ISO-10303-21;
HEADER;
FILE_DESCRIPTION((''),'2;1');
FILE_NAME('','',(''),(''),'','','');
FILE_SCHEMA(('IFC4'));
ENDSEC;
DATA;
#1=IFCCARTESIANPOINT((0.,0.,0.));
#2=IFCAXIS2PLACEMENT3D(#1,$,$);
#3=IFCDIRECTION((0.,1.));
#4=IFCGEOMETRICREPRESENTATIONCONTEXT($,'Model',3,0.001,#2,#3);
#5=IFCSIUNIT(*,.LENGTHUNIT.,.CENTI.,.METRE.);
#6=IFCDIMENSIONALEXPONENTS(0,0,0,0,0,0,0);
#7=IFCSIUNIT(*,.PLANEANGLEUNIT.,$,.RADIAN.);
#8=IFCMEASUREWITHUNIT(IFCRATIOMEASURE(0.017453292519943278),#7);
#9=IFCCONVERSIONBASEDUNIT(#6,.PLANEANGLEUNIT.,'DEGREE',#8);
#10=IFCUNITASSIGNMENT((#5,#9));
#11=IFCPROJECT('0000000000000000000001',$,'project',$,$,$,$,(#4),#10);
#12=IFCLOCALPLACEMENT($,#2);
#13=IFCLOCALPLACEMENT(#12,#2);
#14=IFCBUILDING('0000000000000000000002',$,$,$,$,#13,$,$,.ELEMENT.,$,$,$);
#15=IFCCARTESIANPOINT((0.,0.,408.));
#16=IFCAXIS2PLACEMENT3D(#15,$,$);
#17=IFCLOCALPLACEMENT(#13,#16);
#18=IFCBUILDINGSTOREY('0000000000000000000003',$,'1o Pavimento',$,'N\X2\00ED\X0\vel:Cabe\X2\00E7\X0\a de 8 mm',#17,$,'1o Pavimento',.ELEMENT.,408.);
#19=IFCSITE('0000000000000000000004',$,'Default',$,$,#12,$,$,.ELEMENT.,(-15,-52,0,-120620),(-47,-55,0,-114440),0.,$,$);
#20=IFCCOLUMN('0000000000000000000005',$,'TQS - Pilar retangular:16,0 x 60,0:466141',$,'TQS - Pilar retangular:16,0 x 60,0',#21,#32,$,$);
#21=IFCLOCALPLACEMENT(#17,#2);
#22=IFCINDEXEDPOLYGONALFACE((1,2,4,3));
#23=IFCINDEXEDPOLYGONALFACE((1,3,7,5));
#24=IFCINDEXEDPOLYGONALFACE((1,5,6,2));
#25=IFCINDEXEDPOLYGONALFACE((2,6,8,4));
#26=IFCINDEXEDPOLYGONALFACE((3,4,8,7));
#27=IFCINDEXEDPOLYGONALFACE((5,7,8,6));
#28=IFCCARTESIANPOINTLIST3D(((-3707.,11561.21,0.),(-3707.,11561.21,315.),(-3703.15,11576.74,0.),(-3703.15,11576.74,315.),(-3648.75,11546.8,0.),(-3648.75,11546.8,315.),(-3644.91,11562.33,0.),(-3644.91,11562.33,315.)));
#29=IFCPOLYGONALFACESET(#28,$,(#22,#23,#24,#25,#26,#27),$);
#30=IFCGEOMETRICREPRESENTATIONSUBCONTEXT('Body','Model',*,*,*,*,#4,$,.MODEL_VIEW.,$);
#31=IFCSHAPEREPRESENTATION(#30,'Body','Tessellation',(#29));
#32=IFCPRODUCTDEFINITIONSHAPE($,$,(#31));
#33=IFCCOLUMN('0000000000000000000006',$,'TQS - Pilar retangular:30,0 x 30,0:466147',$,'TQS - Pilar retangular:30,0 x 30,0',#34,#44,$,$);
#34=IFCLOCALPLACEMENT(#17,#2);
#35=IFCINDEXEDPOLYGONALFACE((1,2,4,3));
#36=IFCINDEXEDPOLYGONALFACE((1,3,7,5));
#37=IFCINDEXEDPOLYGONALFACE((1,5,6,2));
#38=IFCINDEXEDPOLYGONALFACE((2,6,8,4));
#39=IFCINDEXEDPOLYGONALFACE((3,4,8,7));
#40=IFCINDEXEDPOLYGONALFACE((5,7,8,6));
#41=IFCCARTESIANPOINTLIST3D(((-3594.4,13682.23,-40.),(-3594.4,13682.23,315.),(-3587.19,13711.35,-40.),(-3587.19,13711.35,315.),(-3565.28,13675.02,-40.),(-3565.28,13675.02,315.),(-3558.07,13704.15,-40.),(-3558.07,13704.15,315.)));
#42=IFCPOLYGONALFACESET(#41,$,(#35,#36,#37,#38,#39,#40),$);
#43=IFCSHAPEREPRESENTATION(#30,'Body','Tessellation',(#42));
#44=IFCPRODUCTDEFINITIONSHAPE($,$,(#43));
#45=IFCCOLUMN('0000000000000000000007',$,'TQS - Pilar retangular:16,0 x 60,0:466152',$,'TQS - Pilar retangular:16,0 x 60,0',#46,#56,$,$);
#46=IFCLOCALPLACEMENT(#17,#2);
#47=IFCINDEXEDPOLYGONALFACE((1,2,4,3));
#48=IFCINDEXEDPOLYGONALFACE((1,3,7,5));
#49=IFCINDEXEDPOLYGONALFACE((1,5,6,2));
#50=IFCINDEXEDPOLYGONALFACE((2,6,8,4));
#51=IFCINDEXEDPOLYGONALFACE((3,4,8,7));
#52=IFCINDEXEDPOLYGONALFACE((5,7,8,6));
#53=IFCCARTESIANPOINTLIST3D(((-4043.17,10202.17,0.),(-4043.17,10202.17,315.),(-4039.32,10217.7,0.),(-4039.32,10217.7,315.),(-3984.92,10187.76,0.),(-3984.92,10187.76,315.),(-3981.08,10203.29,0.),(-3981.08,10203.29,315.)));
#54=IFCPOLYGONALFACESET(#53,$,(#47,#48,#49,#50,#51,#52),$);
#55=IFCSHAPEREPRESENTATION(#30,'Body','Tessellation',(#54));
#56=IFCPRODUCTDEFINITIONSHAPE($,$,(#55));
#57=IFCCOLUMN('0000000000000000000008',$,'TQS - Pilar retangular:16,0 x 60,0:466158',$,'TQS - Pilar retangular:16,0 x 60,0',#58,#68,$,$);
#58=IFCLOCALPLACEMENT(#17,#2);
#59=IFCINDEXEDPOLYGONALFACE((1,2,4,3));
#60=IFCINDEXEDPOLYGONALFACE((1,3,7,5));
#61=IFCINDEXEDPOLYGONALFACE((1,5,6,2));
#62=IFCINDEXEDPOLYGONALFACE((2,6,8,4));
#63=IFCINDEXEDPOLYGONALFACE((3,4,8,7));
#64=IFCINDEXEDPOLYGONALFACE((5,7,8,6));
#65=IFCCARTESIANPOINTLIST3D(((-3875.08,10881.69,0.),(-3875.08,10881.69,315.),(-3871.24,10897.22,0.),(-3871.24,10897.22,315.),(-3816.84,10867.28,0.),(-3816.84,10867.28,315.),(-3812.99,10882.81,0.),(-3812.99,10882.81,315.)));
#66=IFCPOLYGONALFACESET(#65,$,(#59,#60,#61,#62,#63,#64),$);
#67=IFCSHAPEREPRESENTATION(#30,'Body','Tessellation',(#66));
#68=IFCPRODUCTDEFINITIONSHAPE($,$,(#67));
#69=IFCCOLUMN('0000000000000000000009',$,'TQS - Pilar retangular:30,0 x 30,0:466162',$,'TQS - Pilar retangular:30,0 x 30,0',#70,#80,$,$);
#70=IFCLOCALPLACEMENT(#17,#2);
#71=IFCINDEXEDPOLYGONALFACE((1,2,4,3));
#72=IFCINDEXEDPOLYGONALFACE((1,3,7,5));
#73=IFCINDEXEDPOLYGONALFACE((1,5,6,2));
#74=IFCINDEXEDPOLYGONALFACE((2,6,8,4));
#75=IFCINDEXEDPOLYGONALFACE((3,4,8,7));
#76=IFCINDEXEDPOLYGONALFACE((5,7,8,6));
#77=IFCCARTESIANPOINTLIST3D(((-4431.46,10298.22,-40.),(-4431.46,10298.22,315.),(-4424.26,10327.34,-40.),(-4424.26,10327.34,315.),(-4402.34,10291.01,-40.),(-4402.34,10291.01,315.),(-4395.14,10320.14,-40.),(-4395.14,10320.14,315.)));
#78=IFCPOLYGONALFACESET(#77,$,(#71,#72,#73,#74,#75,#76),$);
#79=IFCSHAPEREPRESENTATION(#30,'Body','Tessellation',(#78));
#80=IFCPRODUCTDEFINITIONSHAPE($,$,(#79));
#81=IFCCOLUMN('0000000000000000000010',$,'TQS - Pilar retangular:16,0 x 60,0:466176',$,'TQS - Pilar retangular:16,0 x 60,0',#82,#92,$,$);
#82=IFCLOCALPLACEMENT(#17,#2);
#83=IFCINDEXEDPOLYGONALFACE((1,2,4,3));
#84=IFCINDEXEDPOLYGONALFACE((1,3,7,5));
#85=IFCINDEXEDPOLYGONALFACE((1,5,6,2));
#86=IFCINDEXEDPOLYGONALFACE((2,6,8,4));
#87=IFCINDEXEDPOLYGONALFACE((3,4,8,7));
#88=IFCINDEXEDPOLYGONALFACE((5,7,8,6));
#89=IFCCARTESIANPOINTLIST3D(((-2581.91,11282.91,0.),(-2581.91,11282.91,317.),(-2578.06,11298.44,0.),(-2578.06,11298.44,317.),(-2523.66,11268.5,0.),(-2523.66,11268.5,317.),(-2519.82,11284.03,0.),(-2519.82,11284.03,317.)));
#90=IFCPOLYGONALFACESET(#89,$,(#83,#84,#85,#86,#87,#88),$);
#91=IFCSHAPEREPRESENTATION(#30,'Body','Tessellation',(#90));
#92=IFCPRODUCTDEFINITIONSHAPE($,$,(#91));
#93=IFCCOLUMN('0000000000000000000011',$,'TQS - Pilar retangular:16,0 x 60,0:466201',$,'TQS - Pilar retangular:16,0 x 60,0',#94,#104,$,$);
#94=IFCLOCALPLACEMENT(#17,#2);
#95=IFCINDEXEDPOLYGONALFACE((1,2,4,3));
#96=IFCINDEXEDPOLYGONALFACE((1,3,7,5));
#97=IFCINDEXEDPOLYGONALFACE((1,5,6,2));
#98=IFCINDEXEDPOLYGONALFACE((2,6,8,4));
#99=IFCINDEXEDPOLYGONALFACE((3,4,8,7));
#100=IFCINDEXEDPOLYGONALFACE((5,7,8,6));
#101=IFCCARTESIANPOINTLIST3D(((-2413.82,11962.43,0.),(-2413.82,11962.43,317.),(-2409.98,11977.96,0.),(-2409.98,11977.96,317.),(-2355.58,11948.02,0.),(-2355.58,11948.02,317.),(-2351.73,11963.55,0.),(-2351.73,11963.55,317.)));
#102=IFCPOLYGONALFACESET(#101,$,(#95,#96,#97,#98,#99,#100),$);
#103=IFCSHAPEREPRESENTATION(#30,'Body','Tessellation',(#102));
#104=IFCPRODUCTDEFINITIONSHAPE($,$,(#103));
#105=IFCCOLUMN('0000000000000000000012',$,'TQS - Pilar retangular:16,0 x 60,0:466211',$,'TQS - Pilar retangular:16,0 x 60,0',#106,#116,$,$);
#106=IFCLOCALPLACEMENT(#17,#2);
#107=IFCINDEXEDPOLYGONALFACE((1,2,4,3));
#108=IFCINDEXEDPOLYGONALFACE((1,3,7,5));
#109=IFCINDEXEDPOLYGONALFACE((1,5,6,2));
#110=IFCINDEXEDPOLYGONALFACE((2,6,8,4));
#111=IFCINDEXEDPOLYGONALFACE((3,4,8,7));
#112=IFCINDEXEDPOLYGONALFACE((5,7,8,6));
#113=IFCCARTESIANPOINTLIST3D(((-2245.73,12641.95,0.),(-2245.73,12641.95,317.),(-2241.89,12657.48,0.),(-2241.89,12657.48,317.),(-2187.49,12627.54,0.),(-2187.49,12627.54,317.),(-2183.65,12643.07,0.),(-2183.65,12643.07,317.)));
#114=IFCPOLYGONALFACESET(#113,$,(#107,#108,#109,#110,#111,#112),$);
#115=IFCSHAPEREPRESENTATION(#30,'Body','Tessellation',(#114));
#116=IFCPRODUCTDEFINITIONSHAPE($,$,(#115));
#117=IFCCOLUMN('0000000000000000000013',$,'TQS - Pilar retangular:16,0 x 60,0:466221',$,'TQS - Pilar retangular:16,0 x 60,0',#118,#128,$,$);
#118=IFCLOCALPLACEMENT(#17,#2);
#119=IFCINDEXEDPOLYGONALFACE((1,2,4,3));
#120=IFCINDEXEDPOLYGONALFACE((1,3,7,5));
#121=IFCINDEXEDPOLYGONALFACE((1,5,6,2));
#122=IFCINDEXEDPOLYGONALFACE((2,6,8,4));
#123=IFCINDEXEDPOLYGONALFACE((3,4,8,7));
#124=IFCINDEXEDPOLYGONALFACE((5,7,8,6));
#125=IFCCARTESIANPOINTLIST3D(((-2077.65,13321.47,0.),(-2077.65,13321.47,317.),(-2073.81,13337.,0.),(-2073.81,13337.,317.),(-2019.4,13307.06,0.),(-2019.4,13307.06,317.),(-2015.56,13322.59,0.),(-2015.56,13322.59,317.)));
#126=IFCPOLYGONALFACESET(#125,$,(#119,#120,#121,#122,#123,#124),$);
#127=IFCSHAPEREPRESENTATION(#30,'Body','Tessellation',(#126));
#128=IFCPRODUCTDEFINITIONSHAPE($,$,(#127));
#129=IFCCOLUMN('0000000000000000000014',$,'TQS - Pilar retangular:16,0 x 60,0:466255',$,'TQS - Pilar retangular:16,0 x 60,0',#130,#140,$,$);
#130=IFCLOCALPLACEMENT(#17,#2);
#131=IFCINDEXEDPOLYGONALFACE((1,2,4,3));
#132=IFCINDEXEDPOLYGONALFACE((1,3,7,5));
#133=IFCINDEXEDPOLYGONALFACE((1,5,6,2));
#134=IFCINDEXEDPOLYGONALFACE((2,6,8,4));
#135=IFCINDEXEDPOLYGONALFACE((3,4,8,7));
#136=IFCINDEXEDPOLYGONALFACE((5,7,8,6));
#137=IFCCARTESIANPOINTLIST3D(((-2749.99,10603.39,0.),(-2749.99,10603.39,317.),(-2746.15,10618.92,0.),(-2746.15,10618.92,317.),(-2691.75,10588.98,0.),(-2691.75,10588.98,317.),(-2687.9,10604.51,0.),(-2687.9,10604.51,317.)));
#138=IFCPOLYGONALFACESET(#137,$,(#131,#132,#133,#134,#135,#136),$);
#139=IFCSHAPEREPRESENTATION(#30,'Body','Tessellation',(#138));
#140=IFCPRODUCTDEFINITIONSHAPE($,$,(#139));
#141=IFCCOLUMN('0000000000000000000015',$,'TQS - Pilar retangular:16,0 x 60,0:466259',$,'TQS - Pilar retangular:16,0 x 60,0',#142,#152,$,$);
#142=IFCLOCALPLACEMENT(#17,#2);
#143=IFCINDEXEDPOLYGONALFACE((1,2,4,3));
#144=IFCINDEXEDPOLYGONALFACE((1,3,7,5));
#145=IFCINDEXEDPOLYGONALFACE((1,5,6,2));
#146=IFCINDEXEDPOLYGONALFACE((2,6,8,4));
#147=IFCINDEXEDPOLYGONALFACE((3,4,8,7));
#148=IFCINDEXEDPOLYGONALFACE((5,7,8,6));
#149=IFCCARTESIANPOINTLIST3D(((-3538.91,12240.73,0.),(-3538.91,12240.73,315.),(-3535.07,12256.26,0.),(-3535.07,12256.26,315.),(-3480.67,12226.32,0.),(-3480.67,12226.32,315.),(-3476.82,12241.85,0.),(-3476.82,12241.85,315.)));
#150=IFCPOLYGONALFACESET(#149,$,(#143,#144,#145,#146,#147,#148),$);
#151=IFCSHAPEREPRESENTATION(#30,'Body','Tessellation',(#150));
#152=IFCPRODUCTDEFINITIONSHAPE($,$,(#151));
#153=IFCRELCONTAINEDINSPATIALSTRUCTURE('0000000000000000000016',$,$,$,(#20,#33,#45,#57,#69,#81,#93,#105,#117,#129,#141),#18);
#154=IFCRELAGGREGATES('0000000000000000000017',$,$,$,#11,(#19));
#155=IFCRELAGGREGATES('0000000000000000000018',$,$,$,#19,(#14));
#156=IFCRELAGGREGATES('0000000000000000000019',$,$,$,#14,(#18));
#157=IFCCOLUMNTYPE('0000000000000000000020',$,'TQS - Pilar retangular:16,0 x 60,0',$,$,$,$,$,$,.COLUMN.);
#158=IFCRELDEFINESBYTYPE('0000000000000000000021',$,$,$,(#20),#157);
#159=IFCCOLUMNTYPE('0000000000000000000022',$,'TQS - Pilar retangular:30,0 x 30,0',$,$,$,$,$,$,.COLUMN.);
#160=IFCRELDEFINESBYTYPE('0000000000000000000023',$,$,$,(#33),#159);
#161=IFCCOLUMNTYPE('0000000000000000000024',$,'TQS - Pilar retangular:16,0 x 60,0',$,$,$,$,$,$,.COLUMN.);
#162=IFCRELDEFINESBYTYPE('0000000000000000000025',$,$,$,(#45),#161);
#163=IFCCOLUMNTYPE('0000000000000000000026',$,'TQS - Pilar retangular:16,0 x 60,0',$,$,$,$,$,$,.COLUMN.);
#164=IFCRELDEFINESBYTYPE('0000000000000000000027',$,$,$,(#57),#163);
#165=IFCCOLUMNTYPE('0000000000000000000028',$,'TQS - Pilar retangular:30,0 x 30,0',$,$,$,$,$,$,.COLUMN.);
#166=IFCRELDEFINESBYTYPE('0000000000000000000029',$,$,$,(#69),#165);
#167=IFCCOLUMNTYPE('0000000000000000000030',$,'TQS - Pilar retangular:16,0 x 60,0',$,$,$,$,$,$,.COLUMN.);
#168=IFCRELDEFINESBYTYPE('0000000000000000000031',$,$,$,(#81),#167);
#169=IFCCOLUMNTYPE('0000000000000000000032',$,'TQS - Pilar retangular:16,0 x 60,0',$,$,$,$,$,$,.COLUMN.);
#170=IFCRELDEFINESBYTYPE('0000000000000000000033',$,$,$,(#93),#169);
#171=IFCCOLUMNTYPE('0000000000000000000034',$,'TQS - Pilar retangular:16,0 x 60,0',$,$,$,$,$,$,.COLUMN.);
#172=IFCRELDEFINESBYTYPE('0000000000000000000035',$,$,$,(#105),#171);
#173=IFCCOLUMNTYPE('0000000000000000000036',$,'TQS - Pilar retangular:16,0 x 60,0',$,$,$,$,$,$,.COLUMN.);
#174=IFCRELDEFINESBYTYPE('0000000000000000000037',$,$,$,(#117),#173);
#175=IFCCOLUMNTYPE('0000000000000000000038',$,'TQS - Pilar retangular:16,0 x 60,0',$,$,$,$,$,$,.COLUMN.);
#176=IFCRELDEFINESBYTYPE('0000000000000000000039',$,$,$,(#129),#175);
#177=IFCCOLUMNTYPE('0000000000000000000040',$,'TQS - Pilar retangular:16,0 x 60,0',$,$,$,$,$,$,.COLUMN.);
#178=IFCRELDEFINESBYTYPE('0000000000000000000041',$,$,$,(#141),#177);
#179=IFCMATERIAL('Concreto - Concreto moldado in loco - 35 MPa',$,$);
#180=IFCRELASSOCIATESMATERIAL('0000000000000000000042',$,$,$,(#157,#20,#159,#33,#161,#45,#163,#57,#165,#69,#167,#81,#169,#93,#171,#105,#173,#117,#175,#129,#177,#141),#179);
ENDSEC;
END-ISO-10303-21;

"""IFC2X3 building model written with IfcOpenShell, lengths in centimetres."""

from ifc_helpers import new_model, entity, si_unit, converted_unit, direction, frame, frame_2d, origin, origin_2d_with_axis, place, context, subcontext, project, spatial, rectangle, extrude, source, transform, mapped, material, type_object, type_shapes, element, save


model = new_model("IFC2X3")

# Units and contexts
model_context = context("Model", 3, precision=0.001, world=origin(), true_north=direction((0.0, 1.0)))
body_context = subcontext(model_context, "Body", "Model", "MODEL_VIEW")
ifc_project = project(units=[si_unit("LENGTHUNIT", "METRE", prefix="CENTI"), converted_unit("PLANEANGLEUNIT", "DEGREE", entity("IfcRatioMeasure", 0.017453292519943278), si_unit("PLANEANGLEUNIT", "RADIAN"), dimensions=[0, 0, 0, 0, 0, 0, 0])], contexts=[model_context])

# Site, building, storey
site_placement = place(None, origin())
site = spatial("IfcSite", under=ifc_project, at=site_placement, Name="Default", CompositionType="ELEMENT", RefLatitude=(-15, -52, 0, -120620), RefLongitude=(-47, -55, 0, -114440), RefElevation=0.0)
building_placement = place(site_placement, origin())
building = spatial("IfcBuilding", under=site, at=building_placement, CompositionType="ELEMENT")
storey_placement = place(building_placement, frame((0.0, 0.0, 408.0)))
storey = spatial("IfcBuildingStorey", under=building, at=storey_placement, Name="1o Pavimento", ObjectType="Nível:Cabeça de 8 mm", LongName="1o Pavimento", CompositionType="ELEMENT", Elevation=408.0)

# Columns
ifc_material = material(Name="Concreto - Concreto moldado in loco - 35 MPa")
column_type_1 = type_object("IfcColumnType", Name="TQS - Pilar retangular:16,0 x 60,0", PredefinedType="COLUMN", material=ifc_material)
shared_shape_1 = source(origin(), body_context, "Body", "SweptSolid", [
    extrude(rectangle(XDim=60.0, YDim=16.0, at=origin_2d_with_axis()), frame((-3675.95, 11561.77, 408.0), z_axis=(0.0, 0.0, 1.0), x_axis=(-0.970743, 0.240122, 0.0)), (0.0, 0.0, 1.0), 315.0),
])
type_shapes(column_type_1, [shared_shape_1])
column_1_placement = place(storey_placement, frame((0.0, 0.0, -408.0)))
element("IfcColumn", 1, at=column_1_placement, inside=storey, type_object=column_type_1, material=ifc_material, Name="TQS - Pilar retangular:16,0 x 60,0:466141", ObjectType="TQS - Pilar retangular:16,0 x 60,0", context=body_context, shape_type="MappedRepresentation", body=[
    mapped(shared_shape_1, transform((0.0, 0.0, 0.0), scale=1.0)),
])
column_type_2 = type_object("IfcColumnType", Name="TQS - Pilar retangular:30,0 x 30,0", PredefinedType="COLUMN", material=ifc_material)
shared_shape_2 = source(origin(), body_context, "Body", "SweptSolid", [
    extrude(rectangle(XDim=30.0, YDim=30.0, at=frame_2d((0.0, 0.0), x_axis=(1.0, 0.0))), frame((-3576.24, 13693.19, 368.0), z_axis=(0.0, 0.0, 1.0), x_axis=(-0.970743, 0.240122, 0.0)), (0.0, 0.0, 1.0), 355.0),
])
type_shapes(column_type_2, [shared_shape_2])
column_2_placement = place(storey_placement, frame((0.0, 0.0, -408.0)))
element("IfcColumn", 2, at=column_2_placement, inside=storey, type_object=column_type_2, material=ifc_material, Name="TQS - Pilar retangular:30,0 x 30,0:466147", ObjectType="TQS - Pilar retangular:30,0 x 30,0", context=body_context, shape_type="MappedRepresentation", body=[
    mapped(shared_shape_2, transform((0.0, 0.0, 0.0), scale=1.0)),
])
column_type_3 = type_object("IfcColumnType", Name="TQS - Pilar retangular:16,0 x 60,0", PredefinedType="COLUMN", material=ifc_material)
shared_shape_3 = source(origin(), body_context, "Body", "SweptSolid", [
    extrude(rectangle(XDim=60.0, YDim=16.0, at=origin_2d_with_axis()), frame((-4012.12, 10202.73, 408.0), z_axis=(0.0, 0.0, 1.0), x_axis=(-0.970743, 0.240122, 0.0)), (0.0, 0.0, 1.0), 315.0),
])
type_shapes(column_type_3, [shared_shape_3])
column_3_placement = place(storey_placement, frame((0.0, 0.0, -408.0)))
element("IfcColumn", 3, at=column_3_placement, inside=storey, type_object=column_type_3, material=ifc_material, Name="TQS - Pilar retangular:16,0 x 60,0:466152", ObjectType="TQS - Pilar retangular:16,0 x 60,0", context=body_context, shape_type="MappedRepresentation", body=[
    mapped(shared_shape_3, transform((0.0, 0.0, 0.0), scale=1.0)),
])
column_type_4 = type_object("IfcColumnType", Name="TQS - Pilar retangular:16,0 x 60,0", PredefinedType="COLUMN", material=ifc_material)
shared_shape_4 = source(origin(), body_context, "Body", "SweptSolid", [
    extrude(rectangle(XDim=60.0, YDim=16.0, at=origin_2d_with_axis()), frame((-3844.04, 10882.25, 408.0), z_axis=(0.0, 0.0, 1.0), x_axis=(-0.970743, 0.240122, 0.0)), (0.0, 0.0, 1.0), 315.0),
])
type_shapes(column_type_4, [shared_shape_4])
column_4_placement = place(storey_placement, frame((0.0, 0.0, -408.0)))
element("IfcColumn", 4, at=column_4_placement, inside=storey, type_object=column_type_4, material=ifc_material, Name="TQS - Pilar retangular:16,0 x 60,0:466158", ObjectType="TQS - Pilar retangular:16,0 x 60,0", context=body_context, shape_type="MappedRepresentation", body=[
    mapped(shared_shape_4, transform((0.0, 0.0, 0.0), scale=1.0)),
])
column_type_5 = type_object("IfcColumnType", Name="TQS - Pilar retangular:30,0 x 30,0", PredefinedType="COLUMN", material=ifc_material)
shared_shape_5 = source(origin(), body_context, "Body", "SweptSolid", [
    extrude(rectangle(XDim=30.0, YDim=30.0, at=origin_2d_with_axis()), frame((-4413.3, 10309.18, 368.0), z_axis=(0.0, 0.0, 1.0), x_axis=(-0.970743, 0.240122, 0.0)), (0.0, 0.0, 1.0), 355.0),
])
type_shapes(column_type_5, [shared_shape_5])
column_5_placement = place(storey_placement, frame((0.0, 0.0, -408.0)))
element("IfcColumn", 5, at=column_5_placement, inside=storey, type_object=column_type_5, material=ifc_material, Name="TQS - Pilar retangular:30,0 x 30,0:466162", ObjectType="TQS - Pilar retangular:30,0 x 30,0", context=body_context, shape_type="MappedRepresentation", body=[
    mapped(shared_shape_5, transform((0.0, 0.0, 0.0), scale=1.0)),
])
column_type_6 = type_object("IfcColumnType", Name="TQS - Pilar retangular:16,0 x 60,0", PredefinedType="COLUMN", material=ifc_material)
shared_shape_6 = source(origin(), body_context, "Body", "SweptSolid", [
    extrude(rectangle(XDim=60.0, YDim=16.0, at=origin_2d_with_axis()), frame((-2550.86, 11283.47, 408.0), z_axis=(0.0, 0.0, 1.0), x_axis=(-0.970743, 0.240122, 0.0)), (0.0, 0.0, 1.0), 317.0),
])
type_shapes(column_type_6, [shared_shape_6])
column_6_placement = place(storey_placement, frame((0.0, 0.0, -408.0)))
element("IfcColumn", 6, at=column_6_placement, inside=storey, type_object=column_type_6, material=ifc_material, Name="TQS - Pilar retangular:16,0 x 60,0:466176", ObjectType="TQS - Pilar retangular:16,0 x 60,0", context=body_context, shape_type="MappedRepresentation", body=[
    mapped(shared_shape_6, transform((0.0, 0.0, 0.0), scale=1.0)),
])
column_type_7 = type_object("IfcColumnType", Name="TQS - Pilar retangular:16,0 x 60,0", PredefinedType="COLUMN", material=ifc_material)
shared_shape_7 = source(origin(), body_context, "Body", "SweptSolid", [
    extrude(rectangle(XDim=60.0, YDim=16.0, at=origin_2d_with_axis()), frame((-2382.78, 11962.99, 408.0), z_axis=(0.0, 0.0, 1.0), x_axis=(-0.970743, 0.240122, 0.0)), (0.0, 0.0, 1.0), 317.0),
])
type_shapes(column_type_7, [shared_shape_7])
column_7_placement = place(storey_placement, frame((0.0, 0.0, -408.0)))
element("IfcColumn", 7, at=column_7_placement, inside=storey, type_object=column_type_7, material=ifc_material, Name="TQS - Pilar retangular:16,0 x 60,0:466201", ObjectType="TQS - Pilar retangular:16,0 x 60,0", context=body_context, shape_type="MappedRepresentation", body=[
    mapped(shared_shape_7, transform((0.0, 0.0, 0.0), scale=1.0)),
])
column_type_8 = type_object("IfcColumnType", Name="TQS - Pilar retangular:16,0 x 60,0", PredefinedType="COLUMN", material=ifc_material)
shared_shape_8 = source(origin(), body_context, "Body", "SweptSolid", [
    extrude(rectangle(XDim=60.0, YDim=16.0, at=origin_2d_with_axis()), frame((-2214.69, 12642.51, 408.0), z_axis=(0.0, 0.0, 1.0), x_axis=(-0.970743, 0.240122, 0.0)), (0.0, 0.0, 1.0), 317.0),
])
type_shapes(column_type_8, [shared_shape_8])
column_8_placement = place(storey_placement, frame((0.0, 0.0, -408.0)))
element("IfcColumn", 8, at=column_8_placement, inside=storey, type_object=column_type_8, material=ifc_material, Name="TQS - Pilar retangular:16,0 x 60,0:466211", ObjectType="TQS - Pilar retangular:16,0 x 60,0", context=body_context, shape_type="MappedRepresentation", body=[
    mapped(shared_shape_8, transform((0.0, 0.0, 0.0), scale=1.0)),
])
column_type_9 = type_object("IfcColumnType", Name="TQS - Pilar retangular:16,0 x 60,0", PredefinedType="COLUMN", material=ifc_material)
shared_shape_9 = source(origin(), body_context, "Body", "SweptSolid", [
    extrude(rectangle(XDim=60.0, YDim=16.0, at=origin_2d_with_axis()), frame((-2046.61, 13322.03, 408.0), z_axis=(0.0, 0.0, 1.0), x_axis=(-0.970743, 0.240122, 0.0)), (0.0, 0.0, 1.0), 317.0),
])
type_shapes(column_type_9, [shared_shape_9])
column_9_placement = place(storey_placement, frame((0.0, 0.0, -408.0)))
element("IfcColumn", 9, at=column_9_placement, inside=storey, type_object=column_type_9, material=ifc_material, Name="TQS - Pilar retangular:16,0 x 60,0:466221", ObjectType="TQS - Pilar retangular:16,0 x 60,0", context=body_context, shape_type="MappedRepresentation", body=[
    mapped(shared_shape_9, transform((0.0, 0.0, 0.0), scale=1.0)),
])
column_type_10 = type_object("IfcColumnType", Name="TQS - Pilar retangular:16,0 x 60,0", PredefinedType="COLUMN", material=ifc_material)
shared_shape_10 = source(origin(), body_context, "Body", "SweptSolid", [
    extrude(rectangle(XDim=60.0, YDim=16.0, at=origin_2d_with_axis()), frame((-2718.95, 10603.95, 408.0), z_axis=(0.0, 0.0, 1.0), x_axis=(-0.970743, 0.240122, 0.0)), (0.0, 0.0, 1.0), 317.0),
])
type_shapes(column_type_10, [shared_shape_10])
column_10_placement = place(storey_placement, frame((0.0, 0.0, -408.0)))
element("IfcColumn", 10, at=column_10_placement, inside=storey, type_object=column_type_10, material=ifc_material, Name="TQS - Pilar retangular:16,0 x 60,0:466255", ObjectType="TQS - Pilar retangular:16,0 x 60,0", context=body_context, shape_type="MappedRepresentation", body=[
    mapped(shared_shape_10, transform((0.0, 0.0, 0.0), scale=1.0)),
])
column_type_11 = type_object("IfcColumnType", Name="TQS - Pilar retangular:16,0 x 60,0", PredefinedType="COLUMN", material=ifc_material)
shared_shape_11 = source(origin(), body_context, "Body", "SweptSolid", [
    extrude(rectangle(XDim=60.0, YDim=16.0, at=origin_2d_with_axis()), frame((-3507.87, 12241.29, 408.0), z_axis=(0.0, 0.0, 1.0), x_axis=(-0.970743, 0.240122, 0.0)), (0.0, 0.0, 1.0), 315.0),
])
type_shapes(column_type_11, [shared_shape_11])
column_11_placement = place(storey_placement, frame((0.0, 0.0, -408.0)))
element("IfcColumn", 11, at=column_11_placement, inside=storey, type_object=column_type_11, material=ifc_material, Name="TQS - Pilar retangular:16,0 x 60,0:466259", ObjectType="TQS - Pilar retangular:16,0 x 60,0", context=body_context, shape_type="MappedRepresentation", body=[
    mapped(shared_shape_11, transform((0.0, 0.0, 0.0), scale=1.0)),
])

save(model, "model.ifc")
